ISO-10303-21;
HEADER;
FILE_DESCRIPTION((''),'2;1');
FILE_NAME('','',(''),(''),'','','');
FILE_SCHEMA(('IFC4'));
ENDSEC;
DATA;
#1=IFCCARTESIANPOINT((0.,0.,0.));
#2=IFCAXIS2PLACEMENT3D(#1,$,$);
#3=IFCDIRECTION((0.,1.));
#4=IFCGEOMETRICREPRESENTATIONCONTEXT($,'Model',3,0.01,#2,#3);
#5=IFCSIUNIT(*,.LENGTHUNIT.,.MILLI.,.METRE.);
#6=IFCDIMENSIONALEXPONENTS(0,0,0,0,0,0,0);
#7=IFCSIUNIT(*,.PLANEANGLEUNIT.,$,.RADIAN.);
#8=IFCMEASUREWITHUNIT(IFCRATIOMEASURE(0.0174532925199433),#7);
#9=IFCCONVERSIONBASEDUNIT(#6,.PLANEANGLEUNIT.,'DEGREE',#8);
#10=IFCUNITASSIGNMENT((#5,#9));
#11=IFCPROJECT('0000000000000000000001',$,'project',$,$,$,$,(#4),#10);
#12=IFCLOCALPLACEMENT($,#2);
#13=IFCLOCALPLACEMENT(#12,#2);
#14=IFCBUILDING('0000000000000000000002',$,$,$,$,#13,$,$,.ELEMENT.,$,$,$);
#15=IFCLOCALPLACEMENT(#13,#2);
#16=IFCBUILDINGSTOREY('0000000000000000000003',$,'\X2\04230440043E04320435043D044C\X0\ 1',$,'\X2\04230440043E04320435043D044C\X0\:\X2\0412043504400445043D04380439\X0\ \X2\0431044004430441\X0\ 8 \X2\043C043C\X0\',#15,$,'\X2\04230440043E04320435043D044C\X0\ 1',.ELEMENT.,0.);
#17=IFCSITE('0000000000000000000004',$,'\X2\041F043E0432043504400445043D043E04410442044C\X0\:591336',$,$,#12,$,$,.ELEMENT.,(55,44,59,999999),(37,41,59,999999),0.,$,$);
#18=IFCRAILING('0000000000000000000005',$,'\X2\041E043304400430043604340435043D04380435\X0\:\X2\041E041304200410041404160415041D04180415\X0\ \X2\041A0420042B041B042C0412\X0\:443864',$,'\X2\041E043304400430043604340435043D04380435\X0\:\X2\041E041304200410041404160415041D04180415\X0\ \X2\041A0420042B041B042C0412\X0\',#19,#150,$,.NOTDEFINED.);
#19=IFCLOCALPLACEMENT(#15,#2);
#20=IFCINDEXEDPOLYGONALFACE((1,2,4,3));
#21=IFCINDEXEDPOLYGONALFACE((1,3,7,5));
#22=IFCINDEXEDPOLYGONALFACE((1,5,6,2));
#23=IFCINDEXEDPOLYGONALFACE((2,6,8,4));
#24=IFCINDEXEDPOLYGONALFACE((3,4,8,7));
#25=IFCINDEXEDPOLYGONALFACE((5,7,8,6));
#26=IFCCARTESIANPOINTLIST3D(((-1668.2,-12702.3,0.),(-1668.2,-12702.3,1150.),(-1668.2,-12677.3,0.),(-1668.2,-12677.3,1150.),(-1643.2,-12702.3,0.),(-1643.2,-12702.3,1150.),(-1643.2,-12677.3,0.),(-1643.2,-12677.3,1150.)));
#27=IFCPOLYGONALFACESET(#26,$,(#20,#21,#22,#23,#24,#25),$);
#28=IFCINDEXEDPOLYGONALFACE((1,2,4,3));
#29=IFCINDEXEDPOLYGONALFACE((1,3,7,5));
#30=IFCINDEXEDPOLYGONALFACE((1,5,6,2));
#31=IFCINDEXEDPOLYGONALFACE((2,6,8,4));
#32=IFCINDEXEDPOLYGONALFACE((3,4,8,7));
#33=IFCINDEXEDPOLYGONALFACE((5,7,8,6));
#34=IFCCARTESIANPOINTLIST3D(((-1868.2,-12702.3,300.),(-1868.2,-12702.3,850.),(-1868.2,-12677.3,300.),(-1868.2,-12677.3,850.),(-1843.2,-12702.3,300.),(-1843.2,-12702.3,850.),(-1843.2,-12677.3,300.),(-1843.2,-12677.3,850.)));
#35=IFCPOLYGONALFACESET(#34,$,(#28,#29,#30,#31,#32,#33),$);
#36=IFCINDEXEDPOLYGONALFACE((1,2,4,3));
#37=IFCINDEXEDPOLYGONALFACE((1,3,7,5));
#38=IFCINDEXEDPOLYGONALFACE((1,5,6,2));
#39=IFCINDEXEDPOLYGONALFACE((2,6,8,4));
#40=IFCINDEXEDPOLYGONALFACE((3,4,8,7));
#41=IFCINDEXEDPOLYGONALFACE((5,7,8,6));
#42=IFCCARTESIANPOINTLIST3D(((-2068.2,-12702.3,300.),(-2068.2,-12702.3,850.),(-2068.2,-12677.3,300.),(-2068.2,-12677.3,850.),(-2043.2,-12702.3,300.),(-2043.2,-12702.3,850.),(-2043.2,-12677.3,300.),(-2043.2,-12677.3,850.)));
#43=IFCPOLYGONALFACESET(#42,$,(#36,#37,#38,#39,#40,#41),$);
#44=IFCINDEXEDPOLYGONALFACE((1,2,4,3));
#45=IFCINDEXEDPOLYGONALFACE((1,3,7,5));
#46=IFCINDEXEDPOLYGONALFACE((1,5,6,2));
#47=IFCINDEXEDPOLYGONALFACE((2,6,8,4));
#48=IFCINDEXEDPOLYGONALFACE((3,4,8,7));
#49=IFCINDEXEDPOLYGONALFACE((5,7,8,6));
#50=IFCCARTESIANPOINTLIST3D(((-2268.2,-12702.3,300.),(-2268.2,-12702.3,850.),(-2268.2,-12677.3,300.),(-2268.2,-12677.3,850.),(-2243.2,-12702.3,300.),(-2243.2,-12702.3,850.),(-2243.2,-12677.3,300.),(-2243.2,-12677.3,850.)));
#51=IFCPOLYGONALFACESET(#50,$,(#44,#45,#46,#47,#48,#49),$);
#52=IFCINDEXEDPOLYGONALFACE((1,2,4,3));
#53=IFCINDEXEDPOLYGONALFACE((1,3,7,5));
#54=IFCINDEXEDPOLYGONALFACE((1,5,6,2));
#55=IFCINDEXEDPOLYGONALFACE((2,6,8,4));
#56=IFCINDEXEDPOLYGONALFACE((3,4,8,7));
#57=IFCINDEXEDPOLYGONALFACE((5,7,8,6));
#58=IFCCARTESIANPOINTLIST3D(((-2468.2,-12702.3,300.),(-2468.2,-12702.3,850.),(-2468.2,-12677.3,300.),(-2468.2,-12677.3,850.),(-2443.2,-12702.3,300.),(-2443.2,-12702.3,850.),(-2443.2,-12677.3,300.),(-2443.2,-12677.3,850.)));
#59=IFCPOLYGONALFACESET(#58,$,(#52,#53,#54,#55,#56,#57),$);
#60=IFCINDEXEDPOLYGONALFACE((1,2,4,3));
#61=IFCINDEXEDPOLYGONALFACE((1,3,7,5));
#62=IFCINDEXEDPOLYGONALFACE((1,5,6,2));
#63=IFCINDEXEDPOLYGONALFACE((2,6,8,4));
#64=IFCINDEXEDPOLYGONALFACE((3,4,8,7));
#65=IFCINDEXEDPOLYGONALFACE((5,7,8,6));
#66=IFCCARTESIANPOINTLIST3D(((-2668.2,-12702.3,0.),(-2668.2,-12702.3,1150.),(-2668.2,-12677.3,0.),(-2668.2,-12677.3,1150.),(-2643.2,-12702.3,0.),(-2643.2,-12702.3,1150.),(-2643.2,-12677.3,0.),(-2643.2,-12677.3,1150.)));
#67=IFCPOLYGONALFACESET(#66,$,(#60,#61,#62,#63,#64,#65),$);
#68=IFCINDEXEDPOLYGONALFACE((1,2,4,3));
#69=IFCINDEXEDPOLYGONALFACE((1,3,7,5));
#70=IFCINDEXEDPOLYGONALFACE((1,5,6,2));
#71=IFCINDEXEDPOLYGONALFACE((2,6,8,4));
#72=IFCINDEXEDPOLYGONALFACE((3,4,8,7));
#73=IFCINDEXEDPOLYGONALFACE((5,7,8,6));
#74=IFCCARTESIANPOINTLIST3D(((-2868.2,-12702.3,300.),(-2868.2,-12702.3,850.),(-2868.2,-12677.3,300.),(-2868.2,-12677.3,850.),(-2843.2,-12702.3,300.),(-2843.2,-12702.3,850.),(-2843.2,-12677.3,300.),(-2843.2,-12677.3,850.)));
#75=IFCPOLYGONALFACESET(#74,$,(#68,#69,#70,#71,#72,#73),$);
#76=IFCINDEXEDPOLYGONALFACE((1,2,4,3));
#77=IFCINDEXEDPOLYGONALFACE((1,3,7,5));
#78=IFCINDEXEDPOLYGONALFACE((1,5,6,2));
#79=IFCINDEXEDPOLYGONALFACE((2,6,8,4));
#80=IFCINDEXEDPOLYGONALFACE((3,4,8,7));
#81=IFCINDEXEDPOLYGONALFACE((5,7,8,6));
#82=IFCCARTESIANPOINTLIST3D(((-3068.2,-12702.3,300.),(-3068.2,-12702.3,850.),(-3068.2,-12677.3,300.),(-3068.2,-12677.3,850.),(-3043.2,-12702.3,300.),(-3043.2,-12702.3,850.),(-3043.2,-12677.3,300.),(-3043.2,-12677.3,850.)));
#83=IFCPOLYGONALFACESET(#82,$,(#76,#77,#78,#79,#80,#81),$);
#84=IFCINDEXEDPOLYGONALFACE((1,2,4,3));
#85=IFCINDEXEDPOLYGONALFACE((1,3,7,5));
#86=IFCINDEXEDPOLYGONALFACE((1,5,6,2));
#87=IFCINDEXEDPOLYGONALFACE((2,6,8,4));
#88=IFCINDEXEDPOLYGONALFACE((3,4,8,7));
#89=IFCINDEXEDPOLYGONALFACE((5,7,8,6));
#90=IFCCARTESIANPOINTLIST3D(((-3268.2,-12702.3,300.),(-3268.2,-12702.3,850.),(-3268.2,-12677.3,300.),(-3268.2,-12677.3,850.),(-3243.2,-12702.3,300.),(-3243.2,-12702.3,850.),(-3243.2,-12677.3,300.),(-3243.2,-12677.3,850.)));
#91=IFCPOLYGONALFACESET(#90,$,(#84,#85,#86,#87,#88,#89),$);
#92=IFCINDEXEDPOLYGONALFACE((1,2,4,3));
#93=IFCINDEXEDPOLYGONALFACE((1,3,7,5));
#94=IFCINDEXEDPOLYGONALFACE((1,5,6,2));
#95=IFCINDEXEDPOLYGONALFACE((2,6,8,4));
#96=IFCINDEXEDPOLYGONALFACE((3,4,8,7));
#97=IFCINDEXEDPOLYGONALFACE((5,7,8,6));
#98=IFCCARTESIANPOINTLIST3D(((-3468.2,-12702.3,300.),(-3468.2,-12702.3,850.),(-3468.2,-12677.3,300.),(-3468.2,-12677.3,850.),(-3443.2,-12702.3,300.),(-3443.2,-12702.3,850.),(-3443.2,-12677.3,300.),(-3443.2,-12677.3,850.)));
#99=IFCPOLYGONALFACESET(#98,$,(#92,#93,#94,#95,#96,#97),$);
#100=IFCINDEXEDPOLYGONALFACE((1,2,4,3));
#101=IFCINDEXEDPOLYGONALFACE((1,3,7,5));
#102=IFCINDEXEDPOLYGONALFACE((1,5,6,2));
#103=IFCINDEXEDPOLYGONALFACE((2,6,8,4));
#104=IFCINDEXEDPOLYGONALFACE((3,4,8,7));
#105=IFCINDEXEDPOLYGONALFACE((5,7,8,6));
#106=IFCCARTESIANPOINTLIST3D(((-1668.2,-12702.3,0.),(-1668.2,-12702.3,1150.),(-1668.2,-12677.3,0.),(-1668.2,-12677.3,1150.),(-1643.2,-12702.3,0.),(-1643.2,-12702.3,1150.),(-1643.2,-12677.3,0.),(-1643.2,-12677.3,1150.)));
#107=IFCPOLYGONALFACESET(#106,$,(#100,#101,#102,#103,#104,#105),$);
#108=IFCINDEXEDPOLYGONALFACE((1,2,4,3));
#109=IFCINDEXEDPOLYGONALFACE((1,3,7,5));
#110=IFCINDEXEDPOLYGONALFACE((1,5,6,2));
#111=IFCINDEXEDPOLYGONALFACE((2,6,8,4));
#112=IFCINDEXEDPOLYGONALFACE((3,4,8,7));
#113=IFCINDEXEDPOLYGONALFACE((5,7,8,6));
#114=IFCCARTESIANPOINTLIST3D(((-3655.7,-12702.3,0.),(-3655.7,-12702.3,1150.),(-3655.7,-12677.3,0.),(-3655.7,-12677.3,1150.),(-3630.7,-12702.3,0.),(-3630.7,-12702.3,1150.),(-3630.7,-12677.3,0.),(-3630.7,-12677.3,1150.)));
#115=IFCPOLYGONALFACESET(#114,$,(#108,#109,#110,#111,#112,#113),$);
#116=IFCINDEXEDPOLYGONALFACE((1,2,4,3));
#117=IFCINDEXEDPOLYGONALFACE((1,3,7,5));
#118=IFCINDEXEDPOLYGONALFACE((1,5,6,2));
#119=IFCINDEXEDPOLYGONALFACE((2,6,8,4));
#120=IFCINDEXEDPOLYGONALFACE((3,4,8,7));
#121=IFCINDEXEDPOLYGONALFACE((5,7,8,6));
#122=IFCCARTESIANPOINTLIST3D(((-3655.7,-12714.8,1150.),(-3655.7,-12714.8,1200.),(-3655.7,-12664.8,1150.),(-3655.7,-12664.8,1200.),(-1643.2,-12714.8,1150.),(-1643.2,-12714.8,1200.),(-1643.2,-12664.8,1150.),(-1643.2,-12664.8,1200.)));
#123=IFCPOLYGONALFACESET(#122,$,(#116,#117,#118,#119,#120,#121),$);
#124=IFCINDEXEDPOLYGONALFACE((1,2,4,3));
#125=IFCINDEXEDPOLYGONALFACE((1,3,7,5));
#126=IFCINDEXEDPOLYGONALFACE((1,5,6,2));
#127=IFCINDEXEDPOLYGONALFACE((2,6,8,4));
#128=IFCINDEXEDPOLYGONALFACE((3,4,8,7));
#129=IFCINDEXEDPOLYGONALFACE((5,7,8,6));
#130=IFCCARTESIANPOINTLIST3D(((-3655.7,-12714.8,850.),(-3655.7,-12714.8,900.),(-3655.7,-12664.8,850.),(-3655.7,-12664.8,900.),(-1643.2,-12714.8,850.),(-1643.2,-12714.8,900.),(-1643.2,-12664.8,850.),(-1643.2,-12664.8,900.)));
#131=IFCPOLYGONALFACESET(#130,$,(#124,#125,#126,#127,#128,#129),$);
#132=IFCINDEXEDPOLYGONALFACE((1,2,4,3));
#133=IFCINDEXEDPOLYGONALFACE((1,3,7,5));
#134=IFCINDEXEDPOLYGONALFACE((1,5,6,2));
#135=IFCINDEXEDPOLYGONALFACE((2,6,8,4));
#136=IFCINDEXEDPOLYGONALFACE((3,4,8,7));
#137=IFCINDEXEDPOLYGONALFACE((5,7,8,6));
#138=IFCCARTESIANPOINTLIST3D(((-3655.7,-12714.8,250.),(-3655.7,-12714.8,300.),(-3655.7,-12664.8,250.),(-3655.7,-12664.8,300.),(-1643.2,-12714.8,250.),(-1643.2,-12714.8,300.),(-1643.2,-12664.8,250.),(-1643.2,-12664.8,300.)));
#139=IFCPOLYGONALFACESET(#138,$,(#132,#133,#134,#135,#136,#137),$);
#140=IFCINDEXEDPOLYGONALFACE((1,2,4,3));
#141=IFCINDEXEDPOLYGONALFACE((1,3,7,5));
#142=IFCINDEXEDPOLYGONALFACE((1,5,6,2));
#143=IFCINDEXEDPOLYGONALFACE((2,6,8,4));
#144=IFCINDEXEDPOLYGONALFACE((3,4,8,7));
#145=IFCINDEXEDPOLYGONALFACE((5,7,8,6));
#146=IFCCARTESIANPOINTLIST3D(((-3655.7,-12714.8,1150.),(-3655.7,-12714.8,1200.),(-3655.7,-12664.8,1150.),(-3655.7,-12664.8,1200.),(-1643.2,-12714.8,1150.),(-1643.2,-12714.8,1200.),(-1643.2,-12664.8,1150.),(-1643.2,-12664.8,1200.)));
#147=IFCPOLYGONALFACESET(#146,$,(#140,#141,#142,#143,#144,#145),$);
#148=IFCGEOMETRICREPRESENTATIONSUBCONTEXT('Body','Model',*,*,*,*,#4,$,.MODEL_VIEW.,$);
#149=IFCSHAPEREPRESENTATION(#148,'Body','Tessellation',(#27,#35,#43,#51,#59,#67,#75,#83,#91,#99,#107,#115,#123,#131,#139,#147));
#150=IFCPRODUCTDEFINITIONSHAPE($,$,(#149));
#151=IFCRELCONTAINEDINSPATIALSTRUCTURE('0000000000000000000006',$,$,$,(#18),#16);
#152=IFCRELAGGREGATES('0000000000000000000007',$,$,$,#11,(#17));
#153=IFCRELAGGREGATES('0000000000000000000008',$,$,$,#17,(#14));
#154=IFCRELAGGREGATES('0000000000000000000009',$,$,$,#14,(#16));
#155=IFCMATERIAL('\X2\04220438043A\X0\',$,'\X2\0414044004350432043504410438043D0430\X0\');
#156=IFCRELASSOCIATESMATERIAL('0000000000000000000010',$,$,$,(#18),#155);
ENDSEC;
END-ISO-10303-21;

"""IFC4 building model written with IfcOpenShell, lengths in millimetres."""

from ifc_helpers import new_model, entity, si_unit, converted_unit, direction, frame, origin, place, context, subcontext, project, spatial, indexed_curve, outline, extrude, material, element, save


model = new_model("IFC4")

# Units and contexts
model_context = context("Model", 3, precision=0.01, world=origin(), true_north=direction((0.0, 1.0)))
body_context = subcontext(model_context, "Body", "Model", "MODEL_VIEW")
ifc_project = project(units=[si_unit("LENGTHUNIT", "METRE", prefix="MILLI"), converted_unit("PLANEANGLEUNIT", "DEGREE", entity("IfcRatioMeasure", 0.0174532925199433), si_unit("PLANEANGLEUNIT", "RADIAN"), dimensions=[0, 0, 0, 0, 0, 0, 0])], contexts=[model_context])

# Site, building, storey
site_placement = place(None, origin())
site = spatial("IfcSite", under=ifc_project, at=site_placement, Name="Поверхность:591336", CompositionType="ELEMENT", RefLatitude=(55, 44, 59, 999999), RefLongitude=(37, 41, 59, 999999), RefElevation=0.0)
building_placement = place(site_placement, origin())
building = spatial("IfcBuilding", under=site, at=building_placement, CompositionType="ELEMENT")
storey_placement = place(building_placement, origin())
storey = spatial("IfcBuildingStorey", under=building, at=storey_placement, Name="Уровень 1", ObjectType="Уровень:Верхний брус 8 мм", LongName="Уровень 1", CompositionType="ELEMENT", Elevation=0.0)

# Railing
ifc_material_1 = material(Name="Тик", Category="Древесина")
railing_1_placement = place(storey_placement, origin())
element("IfcRailing", 1, at=railing_1_placement, inside=storey, material=ifc_material_1, Name="Ограждение:ОГРАДЖЕНИЕ КРЫЛЬВ:443864", ObjectType="Ограждение:ОГРАДЖЕНИЕ КРЫЛЬВ", PredefinedType="NOTDEFINED", context=body_context, shape_type="SweptSolid", body=[
    extrude(outline(indexed_curve([(-12.5, -12.5), (12.5, -12.5), (12.5, 12.5), (-12.5, 12.5), (-12.5, -12.5)], self_intersect=False)), frame((-1655.7, -12689.8, 0.0), z_axis=(0.0, 0.0, 1.0), x_axis=(0.0, -1.0, 0.0)), (0.0, 0.0, 1.0), 1150.0),
    extrude(outline(indexed_curve([(-12.5, -12.5), (12.5, -12.5), (12.5, 12.5), (-12.5, 12.5), (-12.5, -12.5)], self_intersect=False)), frame((-1855.7, -12689.8, 300.0), z_axis=(0.0, 0.0, 1.0), x_axis=(0.0, -1.0, 0.0)), (0.0, 0.0, 1.0), 550.0),
    extrude(outline(indexed_curve([(-12.5, -12.5), (12.5, -12.5), (12.5, 12.5), (-12.5, 12.5), (-12.5, -12.5)], self_intersect=False)), frame((-2055.7, -12689.8, 300.0), z_axis=(0.0, 0.0, 1.0), x_axis=(0.0, -1.0, 0.0)), (0.0, 0.0, 1.0), 550.0),
    extrude(outline(indexed_curve([(-12.5, -12.5), (12.5, -12.5), (12.5, 12.5), (-12.5, 12.5), (-12.5, -12.5)], self_intersect=False)), frame((-2255.7, -12689.8, 300.0), z_axis=(0.0, 0.0, 1.0), x_axis=(0.0, -1.0, 0.0)), (0.0, 0.0, 1.0), 550.0),
    extrude(outline(indexed_curve([(-12.5, -12.5), (12.5, -12.5), (12.5, 12.5), (-12.5, 12.5), (-12.5, -12.5)], self_intersect=False)), frame((-2455.7, -12689.8, 300.0), z_axis=(0.0, 0.0, 1.0), x_axis=(0.0, -1.0, 0.0)), (0.0, 0.0, 1.0), 550.0),
    extrude(outline(indexed_curve([(-12.5, -12.5), (12.5, -12.5), (12.5, 12.5), (-12.5, 12.5), (-12.5, -12.5)], self_intersect=False)), frame((-2655.7, -12689.8, 0.0), z_axis=(0.0, 0.0, 1.0), x_axis=(0.0, -1.0, 0.0)), (0.0, 0.0, 1.0), 1150.0),
    extrude(outline(indexed_curve([(-12.5, -12.5), (12.5, -12.5), (12.5, 12.5), (-12.5, 12.5), (-12.5, -12.5)], self_intersect=False)), frame((-2855.7, -12689.8, 300.0), z_axis=(0.0, 0.0, 1.0), x_axis=(0.0, -1.0, 0.0)), (0.0, 0.0, 1.0), 550.0),
    extrude(outline(indexed_curve([(-12.5, -12.5), (12.5, -12.5), (12.5, 12.5), (-12.5, 12.5), (-12.5, -12.5)], self_intersect=False)), frame((-3055.7, -12689.8, 300.0), z_axis=(0.0, 0.0, 1.0), x_axis=(0.0, -1.0, 0.0)), (0.0, 0.0, 1.0), 550.0),
    extrude(outline(indexed_curve([(-12.5, -12.5), (12.5, -12.5), (12.5, 12.5), (-12.5, 12.5), (-12.5, -12.5)], self_intersect=False)), frame((-3255.7, -12689.8, 300.0), z_axis=(0.0, 0.0, 1.0), x_axis=(0.0, -1.0, 0.0)), (0.0, 0.0, 1.0), 550.0),
    extrude(outline(indexed_curve([(-12.5, -12.5), (12.5, -12.5), (12.5, 12.5), (-12.5, 12.5), (-12.5, -12.5)], self_intersect=False)), frame((-3455.7, -12689.8, 300.0), z_axis=(0.0, 0.0, 1.0), x_axis=(0.0, -1.0, 0.0)), (0.0, 0.0, 1.0), 550.0),
    extrude(outline(indexed_curve([(-12.5, -12.5), (12.5, -12.5), (12.5, 12.5), (-12.5, 12.5), (-12.5, -12.5)], self_intersect=False)), frame((-1655.7, -12689.8, 0.0), z_axis=(0.0, 0.0, 1.0), x_axis=(0.0, -1.0, 0.0)), (0.0, 0.0, 1.0), 1150.0),
    extrude(outline(indexed_curve([(-12.5, -12.5), (12.5, -12.5), (12.5, 12.5), (-12.5, 12.5), (-12.5, -12.5)], self_intersect=False)), frame((-3643.2, -12689.8, 0.0), z_axis=(0.0, 0.0, 1.0), x_axis=(0.0, -1.0, 0.0)), (0.0, 0.0, 1.0), 1150.0),
    extrude(outline(indexed_curve([(-1006.2, -25.0), (1006.2, -25.0), (1006.2, 25.0), (-1006.2, 25.0), (-1006.2, -25.0)], self_intersect=False)), frame((-2649.4, -12689.8, 1150.0)), (0.0, 0.0, 1.0), 50.0),
    extrude(outline(indexed_curve([(-1006.2, -25.0), (1006.2, -25.0), (1006.2, 25.0), (-1006.2, 25.0), (-1006.2, -25.0)], self_intersect=False)), frame((-2649.4, -12689.8, 850.0)), (0.0, 0.0, 1.0), 50.0),
    extrude(outline(indexed_curve([(-1006.2, -25.0), (1006.2, -25.0), (1006.2, 25.0), (-1006.2, 25.0), (-1006.2, -25.0)], self_intersect=False)), frame((-2649.4, -12689.8, 250.0)), (0.0, 0.0, 1.0), 50.0),
    extrude(outline(indexed_curve([(-1006.2, -25.0), (1006.2, -25.0), (1006.2, 25.0), (-1006.2, 25.0), (-1006.2, -25.0)], self_intersect=False)), frame((-2649.4, -12689.8, 1150.0)), (0.0, 0.0, 1.0), 50.0),
])

save(model, "model.ifc")
